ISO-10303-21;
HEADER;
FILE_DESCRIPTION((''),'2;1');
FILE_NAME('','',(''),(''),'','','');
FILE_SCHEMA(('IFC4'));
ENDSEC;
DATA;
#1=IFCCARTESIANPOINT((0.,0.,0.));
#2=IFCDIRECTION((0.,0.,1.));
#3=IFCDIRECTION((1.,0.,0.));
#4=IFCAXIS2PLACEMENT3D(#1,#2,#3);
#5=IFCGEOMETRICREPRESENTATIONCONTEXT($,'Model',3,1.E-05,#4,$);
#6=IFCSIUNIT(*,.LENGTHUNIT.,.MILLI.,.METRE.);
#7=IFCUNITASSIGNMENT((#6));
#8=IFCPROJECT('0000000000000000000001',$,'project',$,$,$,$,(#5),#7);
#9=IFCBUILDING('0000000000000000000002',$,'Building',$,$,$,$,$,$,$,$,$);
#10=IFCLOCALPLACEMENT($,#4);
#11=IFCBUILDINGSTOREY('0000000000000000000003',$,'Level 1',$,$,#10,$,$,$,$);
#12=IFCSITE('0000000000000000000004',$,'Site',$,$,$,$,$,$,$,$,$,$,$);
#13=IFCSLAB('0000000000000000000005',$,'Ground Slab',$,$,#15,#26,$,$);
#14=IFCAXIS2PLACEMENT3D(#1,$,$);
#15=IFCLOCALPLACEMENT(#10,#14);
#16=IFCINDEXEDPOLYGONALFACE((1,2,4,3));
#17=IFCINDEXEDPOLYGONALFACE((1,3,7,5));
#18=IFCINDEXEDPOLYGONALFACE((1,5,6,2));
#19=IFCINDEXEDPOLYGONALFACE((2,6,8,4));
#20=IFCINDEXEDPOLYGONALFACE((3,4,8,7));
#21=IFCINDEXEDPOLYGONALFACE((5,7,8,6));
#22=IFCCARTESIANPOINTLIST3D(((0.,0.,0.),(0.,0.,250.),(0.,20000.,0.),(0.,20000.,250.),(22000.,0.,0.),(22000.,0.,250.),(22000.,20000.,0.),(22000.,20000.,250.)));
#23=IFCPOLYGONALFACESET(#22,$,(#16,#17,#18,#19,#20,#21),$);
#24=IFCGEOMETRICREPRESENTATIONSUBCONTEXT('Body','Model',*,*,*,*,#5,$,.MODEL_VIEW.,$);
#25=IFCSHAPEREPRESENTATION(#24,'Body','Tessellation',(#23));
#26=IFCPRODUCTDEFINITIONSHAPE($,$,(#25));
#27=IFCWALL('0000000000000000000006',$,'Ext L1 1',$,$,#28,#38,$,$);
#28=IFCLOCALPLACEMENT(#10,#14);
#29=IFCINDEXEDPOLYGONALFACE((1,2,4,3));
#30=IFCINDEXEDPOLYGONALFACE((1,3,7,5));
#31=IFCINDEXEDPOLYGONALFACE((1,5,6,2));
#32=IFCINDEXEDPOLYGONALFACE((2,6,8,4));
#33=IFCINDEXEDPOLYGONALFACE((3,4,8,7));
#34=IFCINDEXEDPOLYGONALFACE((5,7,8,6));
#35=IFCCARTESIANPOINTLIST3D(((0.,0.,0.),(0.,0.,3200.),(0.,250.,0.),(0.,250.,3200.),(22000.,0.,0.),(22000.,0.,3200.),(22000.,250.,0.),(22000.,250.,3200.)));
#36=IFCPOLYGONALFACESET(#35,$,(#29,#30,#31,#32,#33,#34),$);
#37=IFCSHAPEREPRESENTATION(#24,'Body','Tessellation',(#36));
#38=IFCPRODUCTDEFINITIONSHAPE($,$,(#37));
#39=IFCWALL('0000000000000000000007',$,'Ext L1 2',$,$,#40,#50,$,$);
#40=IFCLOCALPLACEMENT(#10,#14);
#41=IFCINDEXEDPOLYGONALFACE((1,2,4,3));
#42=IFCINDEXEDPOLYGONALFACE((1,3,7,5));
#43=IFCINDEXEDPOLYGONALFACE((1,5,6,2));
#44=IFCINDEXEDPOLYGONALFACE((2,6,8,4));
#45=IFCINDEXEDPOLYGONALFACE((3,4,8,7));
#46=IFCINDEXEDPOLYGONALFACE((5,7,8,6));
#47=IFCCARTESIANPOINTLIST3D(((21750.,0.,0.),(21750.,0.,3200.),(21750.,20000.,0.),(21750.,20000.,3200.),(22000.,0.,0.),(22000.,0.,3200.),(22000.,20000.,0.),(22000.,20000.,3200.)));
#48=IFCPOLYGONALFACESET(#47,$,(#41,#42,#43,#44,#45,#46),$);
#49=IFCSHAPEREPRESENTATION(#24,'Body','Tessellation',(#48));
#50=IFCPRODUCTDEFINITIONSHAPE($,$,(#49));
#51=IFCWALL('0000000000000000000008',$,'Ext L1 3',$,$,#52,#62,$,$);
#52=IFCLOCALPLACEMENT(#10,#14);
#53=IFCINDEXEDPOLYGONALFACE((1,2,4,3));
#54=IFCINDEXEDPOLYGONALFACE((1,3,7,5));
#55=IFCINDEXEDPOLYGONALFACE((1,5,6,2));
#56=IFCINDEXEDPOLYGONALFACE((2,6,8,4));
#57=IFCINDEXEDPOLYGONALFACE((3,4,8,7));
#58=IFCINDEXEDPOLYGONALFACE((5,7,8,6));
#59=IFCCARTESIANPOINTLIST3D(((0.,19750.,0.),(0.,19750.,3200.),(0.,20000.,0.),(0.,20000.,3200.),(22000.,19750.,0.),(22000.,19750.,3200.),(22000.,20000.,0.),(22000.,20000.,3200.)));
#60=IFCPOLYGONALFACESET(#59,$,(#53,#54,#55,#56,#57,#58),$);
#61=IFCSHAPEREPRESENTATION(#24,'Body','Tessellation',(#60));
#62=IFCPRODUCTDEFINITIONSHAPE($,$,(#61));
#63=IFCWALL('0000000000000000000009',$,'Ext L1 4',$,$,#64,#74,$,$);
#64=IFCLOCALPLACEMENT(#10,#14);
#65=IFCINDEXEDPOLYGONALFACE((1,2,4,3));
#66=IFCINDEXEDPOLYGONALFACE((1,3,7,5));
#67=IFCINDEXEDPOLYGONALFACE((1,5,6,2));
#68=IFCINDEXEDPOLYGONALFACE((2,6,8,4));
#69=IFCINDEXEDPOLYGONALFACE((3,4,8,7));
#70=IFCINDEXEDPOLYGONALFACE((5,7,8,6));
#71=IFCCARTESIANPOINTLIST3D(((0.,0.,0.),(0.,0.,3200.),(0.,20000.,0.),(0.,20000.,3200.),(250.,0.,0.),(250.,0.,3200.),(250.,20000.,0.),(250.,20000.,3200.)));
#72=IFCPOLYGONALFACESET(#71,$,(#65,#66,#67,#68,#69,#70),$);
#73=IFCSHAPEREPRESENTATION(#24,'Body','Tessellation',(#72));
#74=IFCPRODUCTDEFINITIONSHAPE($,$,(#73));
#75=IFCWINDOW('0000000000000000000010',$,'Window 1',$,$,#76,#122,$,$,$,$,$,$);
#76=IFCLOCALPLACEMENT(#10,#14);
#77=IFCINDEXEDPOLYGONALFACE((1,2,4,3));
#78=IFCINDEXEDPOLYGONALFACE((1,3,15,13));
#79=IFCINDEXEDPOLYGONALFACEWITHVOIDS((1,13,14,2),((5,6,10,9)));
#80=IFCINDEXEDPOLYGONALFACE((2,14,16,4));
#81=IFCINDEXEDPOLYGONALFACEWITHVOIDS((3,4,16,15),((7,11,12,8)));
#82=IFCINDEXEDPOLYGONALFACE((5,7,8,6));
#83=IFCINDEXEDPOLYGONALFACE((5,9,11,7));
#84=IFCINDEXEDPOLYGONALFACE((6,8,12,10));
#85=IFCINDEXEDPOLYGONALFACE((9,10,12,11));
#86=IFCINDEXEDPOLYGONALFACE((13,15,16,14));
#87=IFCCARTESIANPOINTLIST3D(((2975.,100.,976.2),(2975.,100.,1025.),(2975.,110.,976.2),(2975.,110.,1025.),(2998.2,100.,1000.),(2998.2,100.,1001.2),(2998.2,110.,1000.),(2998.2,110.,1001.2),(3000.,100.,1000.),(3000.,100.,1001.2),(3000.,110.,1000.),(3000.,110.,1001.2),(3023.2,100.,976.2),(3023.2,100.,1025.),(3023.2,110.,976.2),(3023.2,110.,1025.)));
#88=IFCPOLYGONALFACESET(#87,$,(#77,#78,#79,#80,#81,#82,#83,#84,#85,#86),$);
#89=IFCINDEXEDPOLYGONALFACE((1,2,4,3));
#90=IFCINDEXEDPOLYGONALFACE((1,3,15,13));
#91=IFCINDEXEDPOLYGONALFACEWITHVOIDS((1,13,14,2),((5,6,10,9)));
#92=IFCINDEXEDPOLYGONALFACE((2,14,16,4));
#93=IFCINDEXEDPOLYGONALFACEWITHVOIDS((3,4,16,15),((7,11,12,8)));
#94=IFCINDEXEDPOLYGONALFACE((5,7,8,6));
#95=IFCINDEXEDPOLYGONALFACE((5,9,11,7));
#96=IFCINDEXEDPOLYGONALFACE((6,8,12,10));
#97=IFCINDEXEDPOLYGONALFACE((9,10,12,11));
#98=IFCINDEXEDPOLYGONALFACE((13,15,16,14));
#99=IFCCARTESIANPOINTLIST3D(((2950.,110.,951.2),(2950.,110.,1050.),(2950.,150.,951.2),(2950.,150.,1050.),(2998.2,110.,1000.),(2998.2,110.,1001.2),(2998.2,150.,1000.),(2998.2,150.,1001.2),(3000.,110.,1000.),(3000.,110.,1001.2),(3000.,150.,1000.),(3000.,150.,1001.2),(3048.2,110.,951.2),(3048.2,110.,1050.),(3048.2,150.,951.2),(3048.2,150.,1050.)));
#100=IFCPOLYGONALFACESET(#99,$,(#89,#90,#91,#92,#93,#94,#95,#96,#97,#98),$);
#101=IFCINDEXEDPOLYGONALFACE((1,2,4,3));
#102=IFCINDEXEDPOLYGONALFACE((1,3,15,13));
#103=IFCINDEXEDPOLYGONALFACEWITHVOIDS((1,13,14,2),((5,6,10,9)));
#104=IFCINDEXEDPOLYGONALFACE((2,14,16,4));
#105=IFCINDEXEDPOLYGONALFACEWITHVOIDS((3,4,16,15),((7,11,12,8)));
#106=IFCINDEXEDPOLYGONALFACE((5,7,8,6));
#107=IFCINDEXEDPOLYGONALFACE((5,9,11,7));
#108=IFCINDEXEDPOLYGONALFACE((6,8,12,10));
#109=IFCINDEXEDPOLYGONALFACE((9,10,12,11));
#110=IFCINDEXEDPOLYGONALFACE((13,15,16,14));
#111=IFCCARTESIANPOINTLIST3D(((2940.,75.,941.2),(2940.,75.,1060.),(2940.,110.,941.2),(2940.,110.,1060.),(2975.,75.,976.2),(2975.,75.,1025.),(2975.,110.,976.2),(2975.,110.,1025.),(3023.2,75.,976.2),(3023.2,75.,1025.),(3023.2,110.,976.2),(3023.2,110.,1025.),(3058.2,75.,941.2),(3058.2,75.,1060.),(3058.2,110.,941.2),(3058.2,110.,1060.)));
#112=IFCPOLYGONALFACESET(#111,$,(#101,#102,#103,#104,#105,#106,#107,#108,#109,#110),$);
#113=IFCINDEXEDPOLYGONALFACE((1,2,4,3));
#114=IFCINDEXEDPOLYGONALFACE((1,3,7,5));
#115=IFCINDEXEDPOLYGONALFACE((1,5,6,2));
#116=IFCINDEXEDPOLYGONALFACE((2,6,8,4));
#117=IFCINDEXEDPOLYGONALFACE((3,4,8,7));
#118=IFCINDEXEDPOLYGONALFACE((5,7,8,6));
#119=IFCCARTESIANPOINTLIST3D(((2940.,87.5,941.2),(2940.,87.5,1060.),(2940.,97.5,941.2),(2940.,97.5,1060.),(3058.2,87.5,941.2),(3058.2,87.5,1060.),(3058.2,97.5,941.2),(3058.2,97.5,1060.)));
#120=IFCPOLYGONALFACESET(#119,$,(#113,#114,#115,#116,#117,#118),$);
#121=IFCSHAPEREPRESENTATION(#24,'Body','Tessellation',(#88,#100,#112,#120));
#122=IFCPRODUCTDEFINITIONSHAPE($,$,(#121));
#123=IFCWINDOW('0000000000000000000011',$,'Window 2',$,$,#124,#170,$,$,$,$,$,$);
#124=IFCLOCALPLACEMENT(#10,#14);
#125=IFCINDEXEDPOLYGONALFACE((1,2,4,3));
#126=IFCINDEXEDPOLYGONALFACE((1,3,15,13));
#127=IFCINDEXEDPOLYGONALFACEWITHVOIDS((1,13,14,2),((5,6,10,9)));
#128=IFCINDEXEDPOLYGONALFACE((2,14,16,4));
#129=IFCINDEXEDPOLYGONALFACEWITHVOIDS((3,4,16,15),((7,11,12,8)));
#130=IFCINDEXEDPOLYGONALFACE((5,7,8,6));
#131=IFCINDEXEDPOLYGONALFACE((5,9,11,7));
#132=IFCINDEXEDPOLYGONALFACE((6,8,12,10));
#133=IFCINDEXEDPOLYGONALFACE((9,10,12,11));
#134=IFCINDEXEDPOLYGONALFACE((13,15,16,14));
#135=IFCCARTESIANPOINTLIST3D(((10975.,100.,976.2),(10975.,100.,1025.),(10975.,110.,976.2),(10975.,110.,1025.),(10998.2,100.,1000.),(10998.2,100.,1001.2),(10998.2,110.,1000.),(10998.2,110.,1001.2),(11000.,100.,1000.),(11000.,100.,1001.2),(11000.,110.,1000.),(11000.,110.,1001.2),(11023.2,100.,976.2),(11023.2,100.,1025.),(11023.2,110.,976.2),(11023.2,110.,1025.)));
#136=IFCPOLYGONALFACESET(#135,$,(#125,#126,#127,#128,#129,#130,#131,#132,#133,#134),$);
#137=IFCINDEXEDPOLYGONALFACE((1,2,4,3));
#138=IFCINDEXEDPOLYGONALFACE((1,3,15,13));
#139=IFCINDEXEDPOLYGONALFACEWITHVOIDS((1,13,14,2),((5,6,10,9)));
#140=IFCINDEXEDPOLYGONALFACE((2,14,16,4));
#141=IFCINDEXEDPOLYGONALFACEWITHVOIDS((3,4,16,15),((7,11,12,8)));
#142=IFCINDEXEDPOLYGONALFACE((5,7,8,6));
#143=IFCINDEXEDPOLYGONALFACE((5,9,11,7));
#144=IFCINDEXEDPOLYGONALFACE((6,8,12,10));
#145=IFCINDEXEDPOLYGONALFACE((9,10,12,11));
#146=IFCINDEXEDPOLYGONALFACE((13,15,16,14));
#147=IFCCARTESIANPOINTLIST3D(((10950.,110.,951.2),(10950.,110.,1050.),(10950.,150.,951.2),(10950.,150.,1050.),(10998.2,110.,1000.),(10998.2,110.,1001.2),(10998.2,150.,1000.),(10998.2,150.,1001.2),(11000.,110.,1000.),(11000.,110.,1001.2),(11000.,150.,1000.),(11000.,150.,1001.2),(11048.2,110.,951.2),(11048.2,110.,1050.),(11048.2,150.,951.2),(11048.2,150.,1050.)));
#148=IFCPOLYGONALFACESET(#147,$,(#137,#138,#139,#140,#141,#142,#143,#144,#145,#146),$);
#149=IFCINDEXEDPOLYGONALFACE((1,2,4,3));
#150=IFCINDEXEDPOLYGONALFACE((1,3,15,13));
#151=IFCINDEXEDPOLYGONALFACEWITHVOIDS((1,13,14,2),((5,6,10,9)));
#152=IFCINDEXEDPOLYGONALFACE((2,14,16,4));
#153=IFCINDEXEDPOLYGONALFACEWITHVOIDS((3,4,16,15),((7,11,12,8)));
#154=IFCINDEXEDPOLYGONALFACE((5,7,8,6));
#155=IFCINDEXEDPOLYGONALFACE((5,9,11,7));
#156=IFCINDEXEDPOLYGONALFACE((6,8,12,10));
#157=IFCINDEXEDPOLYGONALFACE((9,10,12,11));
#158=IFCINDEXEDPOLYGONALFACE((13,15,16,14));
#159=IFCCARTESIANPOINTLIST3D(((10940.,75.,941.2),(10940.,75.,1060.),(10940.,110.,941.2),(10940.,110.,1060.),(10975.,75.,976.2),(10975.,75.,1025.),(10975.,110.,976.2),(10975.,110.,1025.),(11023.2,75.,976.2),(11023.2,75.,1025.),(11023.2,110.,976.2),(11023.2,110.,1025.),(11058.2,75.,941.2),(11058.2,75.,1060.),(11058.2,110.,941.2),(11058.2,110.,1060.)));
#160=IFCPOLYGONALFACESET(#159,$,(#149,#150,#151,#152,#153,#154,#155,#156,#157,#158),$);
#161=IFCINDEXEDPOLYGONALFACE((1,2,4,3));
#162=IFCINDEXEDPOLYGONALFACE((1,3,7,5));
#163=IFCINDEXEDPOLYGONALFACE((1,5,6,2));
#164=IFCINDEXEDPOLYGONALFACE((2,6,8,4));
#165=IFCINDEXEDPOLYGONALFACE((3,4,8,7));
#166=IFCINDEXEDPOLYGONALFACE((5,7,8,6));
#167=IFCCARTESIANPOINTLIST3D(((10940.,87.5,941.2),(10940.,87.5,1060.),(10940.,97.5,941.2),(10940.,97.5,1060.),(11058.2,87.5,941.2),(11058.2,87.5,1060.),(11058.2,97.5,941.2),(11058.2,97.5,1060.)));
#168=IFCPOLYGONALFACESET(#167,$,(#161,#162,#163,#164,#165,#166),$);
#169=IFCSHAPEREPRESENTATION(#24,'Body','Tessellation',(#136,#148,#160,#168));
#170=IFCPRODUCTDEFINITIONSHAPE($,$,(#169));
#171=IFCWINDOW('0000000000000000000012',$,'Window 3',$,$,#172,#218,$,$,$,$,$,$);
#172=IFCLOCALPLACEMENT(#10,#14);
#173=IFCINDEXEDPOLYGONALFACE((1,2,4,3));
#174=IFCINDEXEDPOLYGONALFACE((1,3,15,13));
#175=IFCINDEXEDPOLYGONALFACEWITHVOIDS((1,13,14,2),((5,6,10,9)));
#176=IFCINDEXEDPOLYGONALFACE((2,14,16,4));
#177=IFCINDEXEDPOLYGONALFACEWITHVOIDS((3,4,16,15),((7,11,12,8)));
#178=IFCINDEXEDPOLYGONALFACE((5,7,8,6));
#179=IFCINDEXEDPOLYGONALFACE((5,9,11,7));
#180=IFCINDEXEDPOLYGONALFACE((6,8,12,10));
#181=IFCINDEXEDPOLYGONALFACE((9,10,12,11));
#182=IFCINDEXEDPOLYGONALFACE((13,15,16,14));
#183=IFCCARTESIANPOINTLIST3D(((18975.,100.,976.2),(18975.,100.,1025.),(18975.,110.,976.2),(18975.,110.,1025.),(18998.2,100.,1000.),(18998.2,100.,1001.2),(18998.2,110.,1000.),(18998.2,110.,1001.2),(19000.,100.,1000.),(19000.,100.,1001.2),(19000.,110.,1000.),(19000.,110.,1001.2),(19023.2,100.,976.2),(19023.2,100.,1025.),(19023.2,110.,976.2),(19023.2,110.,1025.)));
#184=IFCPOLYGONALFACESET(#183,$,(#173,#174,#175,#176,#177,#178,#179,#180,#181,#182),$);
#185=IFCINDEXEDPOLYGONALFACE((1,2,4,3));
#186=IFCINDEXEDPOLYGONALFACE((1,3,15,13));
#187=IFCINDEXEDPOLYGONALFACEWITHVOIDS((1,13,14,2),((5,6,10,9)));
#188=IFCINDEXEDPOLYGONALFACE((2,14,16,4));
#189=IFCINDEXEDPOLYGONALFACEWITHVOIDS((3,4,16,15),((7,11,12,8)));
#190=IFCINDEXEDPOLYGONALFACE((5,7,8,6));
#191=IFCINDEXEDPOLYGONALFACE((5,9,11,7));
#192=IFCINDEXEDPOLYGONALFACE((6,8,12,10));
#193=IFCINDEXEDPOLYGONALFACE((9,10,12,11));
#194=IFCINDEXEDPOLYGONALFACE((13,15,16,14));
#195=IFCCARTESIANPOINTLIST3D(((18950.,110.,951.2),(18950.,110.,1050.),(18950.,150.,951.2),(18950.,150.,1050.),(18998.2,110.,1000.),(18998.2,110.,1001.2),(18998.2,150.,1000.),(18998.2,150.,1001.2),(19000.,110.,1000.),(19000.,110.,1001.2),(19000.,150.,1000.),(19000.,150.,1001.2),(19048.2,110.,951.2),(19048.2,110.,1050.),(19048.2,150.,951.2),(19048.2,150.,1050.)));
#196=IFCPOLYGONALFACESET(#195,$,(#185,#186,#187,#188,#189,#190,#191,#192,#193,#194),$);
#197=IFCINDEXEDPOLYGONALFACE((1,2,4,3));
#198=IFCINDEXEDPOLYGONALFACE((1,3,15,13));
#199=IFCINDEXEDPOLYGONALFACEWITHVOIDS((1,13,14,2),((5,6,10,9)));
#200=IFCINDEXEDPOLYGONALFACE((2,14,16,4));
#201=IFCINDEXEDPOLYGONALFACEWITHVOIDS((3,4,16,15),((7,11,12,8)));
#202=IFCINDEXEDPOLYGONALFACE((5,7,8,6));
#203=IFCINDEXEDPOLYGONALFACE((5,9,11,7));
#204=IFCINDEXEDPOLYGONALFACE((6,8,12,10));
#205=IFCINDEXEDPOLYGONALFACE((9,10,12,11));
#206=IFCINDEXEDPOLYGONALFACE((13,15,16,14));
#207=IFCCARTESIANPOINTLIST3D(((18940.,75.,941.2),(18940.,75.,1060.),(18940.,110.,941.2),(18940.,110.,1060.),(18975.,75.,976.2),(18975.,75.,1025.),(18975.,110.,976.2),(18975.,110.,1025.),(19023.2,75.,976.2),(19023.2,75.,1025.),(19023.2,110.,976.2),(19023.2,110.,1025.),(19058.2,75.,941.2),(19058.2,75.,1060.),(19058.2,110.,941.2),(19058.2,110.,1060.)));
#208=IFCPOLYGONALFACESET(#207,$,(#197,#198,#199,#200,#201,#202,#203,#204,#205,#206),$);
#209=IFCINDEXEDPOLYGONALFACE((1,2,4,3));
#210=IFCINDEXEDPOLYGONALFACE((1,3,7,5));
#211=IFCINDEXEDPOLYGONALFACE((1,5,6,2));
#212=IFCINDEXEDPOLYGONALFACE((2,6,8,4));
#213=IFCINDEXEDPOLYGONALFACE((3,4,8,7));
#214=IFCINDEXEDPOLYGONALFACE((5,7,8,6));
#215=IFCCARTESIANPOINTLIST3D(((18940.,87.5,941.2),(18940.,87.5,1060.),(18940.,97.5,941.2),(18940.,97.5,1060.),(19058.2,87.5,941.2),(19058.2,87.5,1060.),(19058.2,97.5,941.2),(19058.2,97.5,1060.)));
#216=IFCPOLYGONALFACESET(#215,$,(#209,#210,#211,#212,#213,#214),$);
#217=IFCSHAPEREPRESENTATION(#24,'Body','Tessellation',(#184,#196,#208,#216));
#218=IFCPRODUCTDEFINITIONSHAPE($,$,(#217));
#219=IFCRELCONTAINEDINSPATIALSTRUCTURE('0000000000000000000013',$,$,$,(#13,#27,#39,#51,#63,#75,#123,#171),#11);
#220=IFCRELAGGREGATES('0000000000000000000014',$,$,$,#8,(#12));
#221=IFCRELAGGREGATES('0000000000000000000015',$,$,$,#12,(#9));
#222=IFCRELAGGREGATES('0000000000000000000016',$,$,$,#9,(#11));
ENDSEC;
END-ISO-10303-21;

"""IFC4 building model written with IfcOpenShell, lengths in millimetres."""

from ifc_helpers import new_model, si_unit, frame, origin_with_axes, place, context, subcontext, project, spatial, line, indexed_curve, outline, extrude, element, save


model = new_model("IFC4")

# Units and contexts
model_context = context("Model", 3, precision=1e-05, world=origin_with_axes())
body_context = subcontext(model_context, "Body", "Model", "MODEL_VIEW")
ifc_project = project(units=[si_unit("LENGTHUNIT", "METRE", prefix="MILLI")], contexts=[model_context])

# Site, building, storey
site = spatial("IfcSite", under=ifc_project, Name="Site")
building = spatial("IfcBuilding", under=site, Name="Building")
storey_placement = place(None, origin_with_axes())
storey = spatial("IfcBuildingStorey", under=building, at=storey_placement, Name="Level 1")

# Slab
slab_placement = place(storey_placement, origin_with_axes())
element("IfcSlab", 1, at=slab_placement, inside=storey, Name="Ground Slab", context=body_context, shape_type="SweptSolid", body=[
    extrude(outline(indexed_curve([(0.0, 0.0), (22000.0, 0.0), (22000.0, 20000.0), (0.0, 20000.0), (0.0, 0.0)])), None, (0.0, 0.0, 1.0), 250.0),
])

# Walls
wall_1_placement = place(storey_placement, origin_with_axes())
element("IfcWall", 2, at=wall_1_placement, inside=storey, Name="Ext L1 1", context=body_context, shape_type="SweptSolid", body=[
    extrude(outline(indexed_curve([(0.0, 0.0), (0.0, 250.0), (22000.0, 250.0), (22000.0, 0.0), (0.0, 0.0)], self_intersect=False)), origin_with_axes(), (0.0, 0.0, 1.0), 3200.0),
])
wall_2_placement = place(storey_placement, frame((22000.0, 0.0, 0.0), z_axis=(0.0, 0.0, 1.0), x_axis=(0.0, 1.0, 0.0)))
element("IfcWall", 3, at=wall_2_placement, inside=storey, Name="Ext L1 2", context=body_context, shape_type="SweptSolid", body=[
    extrude(outline(indexed_curve([(0.0, 0.0), (0.0, 250.0), (20000.0, 250.0), (20000.0, 0.0), (0.0, 0.0)], self_intersect=False)), origin_with_axes(), (0.0, 0.0, 1.0), 3200.0),
])
wall_3_placement = place(storey_placement, frame((22000.0, 20000.0, 0.0), z_axis=(0.0, 0.0, 1.0), x_axis=(-1.0, 0.0, 0.0)))
element("IfcWall", 4, at=wall_3_placement, inside=storey, Name="Ext L1 3", context=body_context, shape_type="SweptSolid", body=[
    extrude(outline(indexed_curve([(0.0, 0.0), (0.0, 250.0), (22000.0, 250.0), (22000.0, 0.0), (0.0, 0.0)], self_intersect=False)), origin_with_axes(), (0.0, 0.0, 1.0), 3200.0),
])
wall_4_placement = place(storey_placement, frame((0.0, 20000.0, 0.0), z_axis=(0.0, 0.0, 1.0), x_axis=(0.0, -1.0, 0.0)))
element("IfcWall", 5, at=wall_4_placement, inside=storey, Name="Ext L1 4", context=body_context, shape_type="SweptSolid", body=[
    extrude(outline(indexed_curve([(0.0, 0.0), (0.0, 250.0), (20000.0, 250.0), (20000.0, 0.0), (0.0, 0.0)], self_intersect=False)), origin_with_axes(), (0.0, 0.0, 1.0), 3200.0),
])

# Windows
for number, where, z_axis, x_axis, name in (
    (6, (3000.0, 200.0, 1000.0), (0.0, 0.0, 1.0), (-1.0, 0.0, 0.0), "Window 1"),
    (7, (11000.0, 200.0, 1000.0), (0.0, 0.0, 1.0), (-1.0, 0.0, 0.0), "Window 2"),
    (8, (19000.0, 200.0, 1000.0), (0.0, 0.0, 1.0), (-1.0, 0.0, 0.0), "Window 3"),
):
    element("IfcWindow", number, at=place(storey_placement, frame(where, z_axis=z_axis, x_axis=x_axis)), inside=storey, Name=name, context=body_context, shape_type="SweptSolid", body=[
        extrude(outline(indexed_curve([(0.0, 0.0), (1.8, 0.0), (1.8, 1.2), (0.0, 1.2)], segments=[line(1, 2, 3, 4, 1)]), holes=[indexed_curve([(25.0, 25.0), (-23.2, 25.0), (-23.2, -23.8), (25.0, -23.8)], segments=[line(1, 2, 3, 4, 1)])]), frame((0.0, 90.0, 0.0), z_axis=(0.0, -1.0, 0.0), x_axis=(1.0, 0.0, 0.0)), (0.0, 0.0, -1.0), 10.0),
        extrude(outline(indexed_curve([(0.0, 0.0), (1.8, 0.0), (1.8, 1.2), (0.0, 1.2)], segments=[line(1, 2, 3, 4, 1)]), holes=[indexed_curve([(50.0, 50.0), (-48.2, 50.0), (-48.2, -48.8), (50.0, -48.8)], segments=[line(1, 2, 3, 4, 1)])]), frame((0.0, 50.0, 0.0), z_axis=(0.0, -1.0, 0.0), x_axis=(1.0, 0.0, 0.0)), (0.0, 0.0, -1.0), 40.0),
        extrude(outline(indexed_curve([(0.0, 0.0), (-48.2, 0.0), (-48.2, -48.8), (0.0, -48.8)], segments=[line(1, 2, 3, 4, 1)]), holes=[indexed_curve([(35.0, 35.0), (-83.2, 35.0), (-83.2, -83.8), (35.0, -83.8)], segments=[line(1, 2, 3, 4, 1)])]), frame((25.0, 90.0, 25.0), z_axis=(0.0, -1.0, 0.0), x_axis=(1.0, 0.0, 0.0)), (0.0, 0.0, -1.0), 35.0),
        extrude(outline(indexed_curve([(35.0, 35.0), (-83.2, 35.0), (-83.2, -83.8), (35.0, -83.8)], segments=[line(1, 2, 3, 4, 1)])), frame((25.0, 102.5, 25.0), z_axis=(0.0, -1.0, 0.0), x_axis=(1.0, 0.0, 0.0)), (0.0, 0.0, -1.0), 10.0),
    ])

save(model, "model.ifc")
